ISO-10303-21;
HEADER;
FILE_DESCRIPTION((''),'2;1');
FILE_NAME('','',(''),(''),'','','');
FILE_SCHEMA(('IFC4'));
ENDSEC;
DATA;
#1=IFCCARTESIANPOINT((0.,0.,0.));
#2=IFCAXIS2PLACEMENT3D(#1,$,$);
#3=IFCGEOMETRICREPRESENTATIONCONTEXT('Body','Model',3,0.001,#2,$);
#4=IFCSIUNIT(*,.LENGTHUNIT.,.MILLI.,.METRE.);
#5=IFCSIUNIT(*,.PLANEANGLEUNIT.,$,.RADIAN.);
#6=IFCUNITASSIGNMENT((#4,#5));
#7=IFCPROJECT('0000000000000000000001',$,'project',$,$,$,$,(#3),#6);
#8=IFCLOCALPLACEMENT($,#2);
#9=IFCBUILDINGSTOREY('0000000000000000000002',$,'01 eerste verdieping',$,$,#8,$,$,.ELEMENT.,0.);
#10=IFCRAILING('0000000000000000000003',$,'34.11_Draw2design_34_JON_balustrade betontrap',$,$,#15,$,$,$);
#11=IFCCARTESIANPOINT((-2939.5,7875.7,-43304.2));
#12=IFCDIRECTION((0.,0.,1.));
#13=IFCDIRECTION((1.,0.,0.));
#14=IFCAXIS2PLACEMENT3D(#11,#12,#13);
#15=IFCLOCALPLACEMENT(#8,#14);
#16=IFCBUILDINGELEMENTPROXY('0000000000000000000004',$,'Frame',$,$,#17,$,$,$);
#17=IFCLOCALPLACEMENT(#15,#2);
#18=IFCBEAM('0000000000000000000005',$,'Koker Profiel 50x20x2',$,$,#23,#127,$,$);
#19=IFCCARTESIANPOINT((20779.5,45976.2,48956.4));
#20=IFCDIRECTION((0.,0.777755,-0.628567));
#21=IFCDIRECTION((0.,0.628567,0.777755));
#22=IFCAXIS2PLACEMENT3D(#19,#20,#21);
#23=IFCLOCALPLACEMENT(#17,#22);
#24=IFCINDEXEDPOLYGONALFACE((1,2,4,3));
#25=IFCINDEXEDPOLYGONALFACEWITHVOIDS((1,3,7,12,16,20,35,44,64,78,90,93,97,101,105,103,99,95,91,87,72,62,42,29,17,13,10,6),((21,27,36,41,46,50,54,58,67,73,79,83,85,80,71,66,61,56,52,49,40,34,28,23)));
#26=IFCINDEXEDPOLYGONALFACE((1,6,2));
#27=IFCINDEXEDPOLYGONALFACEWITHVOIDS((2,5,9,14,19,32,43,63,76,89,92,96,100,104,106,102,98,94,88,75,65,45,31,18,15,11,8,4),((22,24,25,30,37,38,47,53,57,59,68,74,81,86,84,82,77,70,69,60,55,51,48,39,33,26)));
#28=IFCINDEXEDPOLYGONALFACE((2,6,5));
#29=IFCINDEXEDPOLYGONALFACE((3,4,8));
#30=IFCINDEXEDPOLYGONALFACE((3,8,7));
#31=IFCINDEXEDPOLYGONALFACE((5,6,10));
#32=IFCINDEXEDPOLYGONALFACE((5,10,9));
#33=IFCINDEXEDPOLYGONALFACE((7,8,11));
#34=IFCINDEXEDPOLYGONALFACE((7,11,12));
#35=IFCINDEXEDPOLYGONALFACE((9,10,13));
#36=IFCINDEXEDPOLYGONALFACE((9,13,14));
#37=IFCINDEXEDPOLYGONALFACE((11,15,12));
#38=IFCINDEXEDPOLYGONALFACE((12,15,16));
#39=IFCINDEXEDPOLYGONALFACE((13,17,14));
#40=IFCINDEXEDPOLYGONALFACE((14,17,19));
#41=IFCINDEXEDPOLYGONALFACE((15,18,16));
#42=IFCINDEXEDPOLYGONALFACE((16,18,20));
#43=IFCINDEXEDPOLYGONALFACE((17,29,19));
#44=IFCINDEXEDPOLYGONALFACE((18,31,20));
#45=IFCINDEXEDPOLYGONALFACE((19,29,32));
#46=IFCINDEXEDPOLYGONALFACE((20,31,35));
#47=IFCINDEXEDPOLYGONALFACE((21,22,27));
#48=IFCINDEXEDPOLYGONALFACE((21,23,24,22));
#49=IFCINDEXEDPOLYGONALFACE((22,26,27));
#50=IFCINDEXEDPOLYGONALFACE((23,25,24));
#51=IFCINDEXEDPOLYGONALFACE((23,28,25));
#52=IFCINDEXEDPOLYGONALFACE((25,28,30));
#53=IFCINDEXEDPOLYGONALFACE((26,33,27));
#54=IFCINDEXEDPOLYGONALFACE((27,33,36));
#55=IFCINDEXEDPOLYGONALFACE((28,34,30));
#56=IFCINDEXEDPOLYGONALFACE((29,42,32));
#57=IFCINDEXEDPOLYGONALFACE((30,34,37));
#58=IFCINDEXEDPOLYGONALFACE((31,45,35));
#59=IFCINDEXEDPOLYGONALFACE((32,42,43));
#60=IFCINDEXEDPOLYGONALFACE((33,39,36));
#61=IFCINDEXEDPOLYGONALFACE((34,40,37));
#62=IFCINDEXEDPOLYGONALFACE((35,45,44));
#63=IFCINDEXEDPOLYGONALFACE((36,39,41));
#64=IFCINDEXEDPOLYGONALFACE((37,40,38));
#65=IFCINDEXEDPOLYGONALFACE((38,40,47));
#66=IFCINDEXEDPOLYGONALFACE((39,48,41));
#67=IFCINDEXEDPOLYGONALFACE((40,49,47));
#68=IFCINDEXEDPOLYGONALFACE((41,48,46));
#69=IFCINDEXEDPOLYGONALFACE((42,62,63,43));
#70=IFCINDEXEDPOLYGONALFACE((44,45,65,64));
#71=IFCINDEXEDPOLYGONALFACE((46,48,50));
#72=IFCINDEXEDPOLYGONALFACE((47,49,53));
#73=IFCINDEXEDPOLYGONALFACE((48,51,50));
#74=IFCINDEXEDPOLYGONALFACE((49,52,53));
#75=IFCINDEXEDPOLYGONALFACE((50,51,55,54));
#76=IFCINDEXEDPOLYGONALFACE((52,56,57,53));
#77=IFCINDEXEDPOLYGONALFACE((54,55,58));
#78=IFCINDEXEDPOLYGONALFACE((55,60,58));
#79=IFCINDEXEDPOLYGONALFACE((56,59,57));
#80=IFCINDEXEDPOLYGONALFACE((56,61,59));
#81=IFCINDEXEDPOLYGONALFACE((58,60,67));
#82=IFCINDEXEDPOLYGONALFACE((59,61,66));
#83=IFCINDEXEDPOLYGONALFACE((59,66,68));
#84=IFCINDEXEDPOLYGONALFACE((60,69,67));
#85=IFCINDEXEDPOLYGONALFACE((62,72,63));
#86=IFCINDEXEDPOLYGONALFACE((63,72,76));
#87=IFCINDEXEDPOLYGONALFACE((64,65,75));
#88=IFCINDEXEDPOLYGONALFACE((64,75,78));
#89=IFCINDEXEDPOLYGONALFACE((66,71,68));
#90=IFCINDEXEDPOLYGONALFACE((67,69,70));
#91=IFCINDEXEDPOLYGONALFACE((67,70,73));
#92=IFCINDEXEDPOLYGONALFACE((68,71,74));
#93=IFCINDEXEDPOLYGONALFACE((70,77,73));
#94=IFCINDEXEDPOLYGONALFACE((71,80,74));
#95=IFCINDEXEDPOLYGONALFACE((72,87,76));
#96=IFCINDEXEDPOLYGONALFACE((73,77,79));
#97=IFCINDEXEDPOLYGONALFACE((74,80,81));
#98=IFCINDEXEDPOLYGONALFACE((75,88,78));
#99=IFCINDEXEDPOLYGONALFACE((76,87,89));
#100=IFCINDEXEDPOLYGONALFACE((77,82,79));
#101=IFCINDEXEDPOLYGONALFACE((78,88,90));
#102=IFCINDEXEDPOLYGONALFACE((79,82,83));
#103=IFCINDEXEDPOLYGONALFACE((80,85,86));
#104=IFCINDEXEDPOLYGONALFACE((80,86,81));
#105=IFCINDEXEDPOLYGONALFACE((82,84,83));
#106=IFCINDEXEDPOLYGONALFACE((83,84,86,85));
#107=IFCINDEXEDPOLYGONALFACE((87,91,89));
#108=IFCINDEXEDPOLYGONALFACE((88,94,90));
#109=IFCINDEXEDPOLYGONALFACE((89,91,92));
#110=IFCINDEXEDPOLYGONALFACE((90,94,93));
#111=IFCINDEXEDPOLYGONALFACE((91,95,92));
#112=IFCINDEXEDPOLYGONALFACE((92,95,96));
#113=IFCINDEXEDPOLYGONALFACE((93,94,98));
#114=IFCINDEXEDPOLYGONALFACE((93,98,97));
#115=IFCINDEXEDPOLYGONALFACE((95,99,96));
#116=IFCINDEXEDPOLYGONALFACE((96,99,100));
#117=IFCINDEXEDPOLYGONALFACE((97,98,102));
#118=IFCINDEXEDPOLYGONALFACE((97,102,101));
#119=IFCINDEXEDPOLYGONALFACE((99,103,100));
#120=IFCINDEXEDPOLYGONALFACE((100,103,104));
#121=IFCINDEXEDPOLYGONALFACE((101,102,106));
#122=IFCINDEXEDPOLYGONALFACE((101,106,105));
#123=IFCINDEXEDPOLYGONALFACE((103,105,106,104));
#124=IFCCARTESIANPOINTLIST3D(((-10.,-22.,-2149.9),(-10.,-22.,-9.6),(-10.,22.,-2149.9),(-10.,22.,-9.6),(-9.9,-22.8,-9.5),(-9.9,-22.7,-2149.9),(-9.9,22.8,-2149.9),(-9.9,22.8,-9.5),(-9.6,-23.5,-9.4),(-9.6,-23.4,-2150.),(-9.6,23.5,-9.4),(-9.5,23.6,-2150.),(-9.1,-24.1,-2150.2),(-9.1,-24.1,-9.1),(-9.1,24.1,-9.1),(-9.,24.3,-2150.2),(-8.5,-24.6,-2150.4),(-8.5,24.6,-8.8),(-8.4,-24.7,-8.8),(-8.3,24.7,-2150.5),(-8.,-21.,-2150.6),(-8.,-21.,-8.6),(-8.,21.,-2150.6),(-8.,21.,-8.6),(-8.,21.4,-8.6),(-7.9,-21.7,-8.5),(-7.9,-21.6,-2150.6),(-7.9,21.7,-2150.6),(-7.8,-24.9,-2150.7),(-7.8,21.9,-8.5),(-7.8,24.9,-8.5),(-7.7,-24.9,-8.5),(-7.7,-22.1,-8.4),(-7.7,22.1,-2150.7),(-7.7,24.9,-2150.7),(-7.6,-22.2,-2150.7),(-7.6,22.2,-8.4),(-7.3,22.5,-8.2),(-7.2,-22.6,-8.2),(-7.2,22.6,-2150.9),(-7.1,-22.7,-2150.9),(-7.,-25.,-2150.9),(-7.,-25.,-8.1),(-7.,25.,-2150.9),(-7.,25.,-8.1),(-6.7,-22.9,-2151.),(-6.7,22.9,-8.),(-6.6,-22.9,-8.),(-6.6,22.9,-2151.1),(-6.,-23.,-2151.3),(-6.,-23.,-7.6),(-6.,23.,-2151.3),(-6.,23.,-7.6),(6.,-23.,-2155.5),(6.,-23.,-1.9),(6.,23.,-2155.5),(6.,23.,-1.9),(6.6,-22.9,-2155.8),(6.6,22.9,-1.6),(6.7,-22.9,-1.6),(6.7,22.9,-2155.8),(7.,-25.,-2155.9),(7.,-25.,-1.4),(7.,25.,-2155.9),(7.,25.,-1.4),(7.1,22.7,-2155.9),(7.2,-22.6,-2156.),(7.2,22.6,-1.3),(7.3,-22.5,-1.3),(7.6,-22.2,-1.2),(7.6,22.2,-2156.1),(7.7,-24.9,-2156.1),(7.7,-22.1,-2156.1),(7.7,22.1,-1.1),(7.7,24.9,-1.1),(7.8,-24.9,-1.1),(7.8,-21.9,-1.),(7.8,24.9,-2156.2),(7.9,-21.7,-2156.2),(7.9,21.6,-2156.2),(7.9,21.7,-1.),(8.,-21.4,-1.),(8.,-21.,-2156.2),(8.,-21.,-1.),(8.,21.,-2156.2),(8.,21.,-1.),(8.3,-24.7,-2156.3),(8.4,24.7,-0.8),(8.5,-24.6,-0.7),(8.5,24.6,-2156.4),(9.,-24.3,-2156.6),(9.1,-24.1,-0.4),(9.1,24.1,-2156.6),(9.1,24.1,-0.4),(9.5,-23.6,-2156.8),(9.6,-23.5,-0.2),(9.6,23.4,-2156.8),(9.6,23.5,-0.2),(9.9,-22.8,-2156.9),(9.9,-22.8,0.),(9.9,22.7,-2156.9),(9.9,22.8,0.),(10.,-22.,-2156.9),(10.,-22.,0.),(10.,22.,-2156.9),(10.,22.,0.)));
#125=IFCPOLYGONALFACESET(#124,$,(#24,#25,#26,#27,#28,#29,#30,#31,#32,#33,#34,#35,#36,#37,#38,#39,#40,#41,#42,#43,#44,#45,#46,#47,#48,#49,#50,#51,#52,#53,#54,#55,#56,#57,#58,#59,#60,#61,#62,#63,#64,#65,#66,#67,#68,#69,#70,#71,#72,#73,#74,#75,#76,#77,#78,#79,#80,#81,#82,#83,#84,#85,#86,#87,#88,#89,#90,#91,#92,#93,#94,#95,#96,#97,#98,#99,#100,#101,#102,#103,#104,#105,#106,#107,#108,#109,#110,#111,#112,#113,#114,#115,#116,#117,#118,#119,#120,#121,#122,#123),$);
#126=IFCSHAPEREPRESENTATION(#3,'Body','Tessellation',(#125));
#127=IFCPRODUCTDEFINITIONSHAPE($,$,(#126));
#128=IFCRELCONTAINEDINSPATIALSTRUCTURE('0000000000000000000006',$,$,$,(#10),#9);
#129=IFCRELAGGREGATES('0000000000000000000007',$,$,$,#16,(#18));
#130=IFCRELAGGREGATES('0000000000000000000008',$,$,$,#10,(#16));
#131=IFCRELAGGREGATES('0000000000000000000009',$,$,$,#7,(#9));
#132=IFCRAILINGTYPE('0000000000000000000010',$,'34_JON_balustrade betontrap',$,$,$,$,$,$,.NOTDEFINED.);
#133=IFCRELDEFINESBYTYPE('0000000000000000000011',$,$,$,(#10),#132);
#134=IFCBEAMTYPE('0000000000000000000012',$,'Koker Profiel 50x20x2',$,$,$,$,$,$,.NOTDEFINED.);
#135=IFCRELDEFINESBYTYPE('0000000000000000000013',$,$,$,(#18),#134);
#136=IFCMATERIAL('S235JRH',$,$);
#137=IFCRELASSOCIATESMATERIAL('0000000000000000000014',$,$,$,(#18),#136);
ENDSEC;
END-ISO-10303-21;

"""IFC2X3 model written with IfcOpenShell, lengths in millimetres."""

from ifc_helpers import new_model, si_unit, frame, origin, origin_2d, place, context, project, spatial, hollow_rectangle, extrude, clip, halfspace, source, transform, mapped, material, type_object, element, aggregate, save


model = new_model("IFC2X3")

# Units and contexts
model_context = context("Model", 3, precision=0.001, world=origin(), identifier="Body")
ifc_project = project(units=[si_unit("LENGTHUNIT", "METRE", prefix="MILLI"), si_unit("PLANEANGLEUNIT", "RADIAN")], contexts=[model_context])

# Storey
storey_placement = place(None, origin())
storey = spatial("IfcBuildingStorey", under=ifc_project, at=storey_placement, Name="01 eerste verdieping", CompositionType="ELEMENT", Elevation=0.0)

# Railing, building element proxy, beam
railing_type = type_object("IfcRailingType", Name="34_JON_balustrade betontrap")
railing_placement = place(storey_placement, frame((-2939.5, 7875.7, -43304.2), z_axis=(0.0, 0.0, 1.0), x_axis=(1.0, 0.0, 0.0)))
railing = element("IfcRailing", 1, at=railing_placement, inside=storey, type_object=railing_type, Name="34.11_Draw2design_34_JON_balustrade betontrap")
ifc_material_1 = material(Name="S235JRH")
proxy_1_placement = place(railing_placement, origin())
proxy_1 = element("IfcBuildingElementProxy", 2, at=proxy_1_placement, Name="Frame")
beam_type_1 = type_object("IfcBeamType", Name="Koker Profiel 50x20x2")
shared_shape_1 = source(origin(), model_context, "Body", "Clipping", [
    clip(clip(extrude(hollow_rectangle(XDim=20.0, YDim=50.0, WallThickness=2.0, InnerFilletRadius=2.0, OuterFilletRadius=3.0, at=origin_2d()), origin(), (0.0, 0.0, -1.0), 2156.9), halfspace(frame((-10.0, 25.0, -9.6), z_axis=(-0.430948, 0.0, 0.902377), x_axis=(-0.902377, 0.0, -0.430948)), False)), halfspace(frame((-10.0, -25.0, -2149.9), z_axis=(-0.33335, 0.0, -0.942803), x_axis=(0.0, -1.0, 0.0)), False)),
])
beam_1_placement = place(proxy_1_placement, frame((20779.5, 45976.2, 48956.4), z_axis=(0.0, 0.777755, -0.628567), x_axis=(0.0, 0.628567, 0.777755)))
beam_1 = element("IfcBeam", 3, at=beam_1_placement, type_object=beam_type_1, material=ifc_material_1, Name="Koker Profiel 50x20x2", context=model_context, shape_type="MappedRepresentation", body=[
    mapped(shared_shape_1, transform((0.0, 0.0, 0.0), scale=1.0)),
])
aggregate(proxy_1, [beam_1])
aggregate(railing, [proxy_1])

save(model, "model.ifc")
